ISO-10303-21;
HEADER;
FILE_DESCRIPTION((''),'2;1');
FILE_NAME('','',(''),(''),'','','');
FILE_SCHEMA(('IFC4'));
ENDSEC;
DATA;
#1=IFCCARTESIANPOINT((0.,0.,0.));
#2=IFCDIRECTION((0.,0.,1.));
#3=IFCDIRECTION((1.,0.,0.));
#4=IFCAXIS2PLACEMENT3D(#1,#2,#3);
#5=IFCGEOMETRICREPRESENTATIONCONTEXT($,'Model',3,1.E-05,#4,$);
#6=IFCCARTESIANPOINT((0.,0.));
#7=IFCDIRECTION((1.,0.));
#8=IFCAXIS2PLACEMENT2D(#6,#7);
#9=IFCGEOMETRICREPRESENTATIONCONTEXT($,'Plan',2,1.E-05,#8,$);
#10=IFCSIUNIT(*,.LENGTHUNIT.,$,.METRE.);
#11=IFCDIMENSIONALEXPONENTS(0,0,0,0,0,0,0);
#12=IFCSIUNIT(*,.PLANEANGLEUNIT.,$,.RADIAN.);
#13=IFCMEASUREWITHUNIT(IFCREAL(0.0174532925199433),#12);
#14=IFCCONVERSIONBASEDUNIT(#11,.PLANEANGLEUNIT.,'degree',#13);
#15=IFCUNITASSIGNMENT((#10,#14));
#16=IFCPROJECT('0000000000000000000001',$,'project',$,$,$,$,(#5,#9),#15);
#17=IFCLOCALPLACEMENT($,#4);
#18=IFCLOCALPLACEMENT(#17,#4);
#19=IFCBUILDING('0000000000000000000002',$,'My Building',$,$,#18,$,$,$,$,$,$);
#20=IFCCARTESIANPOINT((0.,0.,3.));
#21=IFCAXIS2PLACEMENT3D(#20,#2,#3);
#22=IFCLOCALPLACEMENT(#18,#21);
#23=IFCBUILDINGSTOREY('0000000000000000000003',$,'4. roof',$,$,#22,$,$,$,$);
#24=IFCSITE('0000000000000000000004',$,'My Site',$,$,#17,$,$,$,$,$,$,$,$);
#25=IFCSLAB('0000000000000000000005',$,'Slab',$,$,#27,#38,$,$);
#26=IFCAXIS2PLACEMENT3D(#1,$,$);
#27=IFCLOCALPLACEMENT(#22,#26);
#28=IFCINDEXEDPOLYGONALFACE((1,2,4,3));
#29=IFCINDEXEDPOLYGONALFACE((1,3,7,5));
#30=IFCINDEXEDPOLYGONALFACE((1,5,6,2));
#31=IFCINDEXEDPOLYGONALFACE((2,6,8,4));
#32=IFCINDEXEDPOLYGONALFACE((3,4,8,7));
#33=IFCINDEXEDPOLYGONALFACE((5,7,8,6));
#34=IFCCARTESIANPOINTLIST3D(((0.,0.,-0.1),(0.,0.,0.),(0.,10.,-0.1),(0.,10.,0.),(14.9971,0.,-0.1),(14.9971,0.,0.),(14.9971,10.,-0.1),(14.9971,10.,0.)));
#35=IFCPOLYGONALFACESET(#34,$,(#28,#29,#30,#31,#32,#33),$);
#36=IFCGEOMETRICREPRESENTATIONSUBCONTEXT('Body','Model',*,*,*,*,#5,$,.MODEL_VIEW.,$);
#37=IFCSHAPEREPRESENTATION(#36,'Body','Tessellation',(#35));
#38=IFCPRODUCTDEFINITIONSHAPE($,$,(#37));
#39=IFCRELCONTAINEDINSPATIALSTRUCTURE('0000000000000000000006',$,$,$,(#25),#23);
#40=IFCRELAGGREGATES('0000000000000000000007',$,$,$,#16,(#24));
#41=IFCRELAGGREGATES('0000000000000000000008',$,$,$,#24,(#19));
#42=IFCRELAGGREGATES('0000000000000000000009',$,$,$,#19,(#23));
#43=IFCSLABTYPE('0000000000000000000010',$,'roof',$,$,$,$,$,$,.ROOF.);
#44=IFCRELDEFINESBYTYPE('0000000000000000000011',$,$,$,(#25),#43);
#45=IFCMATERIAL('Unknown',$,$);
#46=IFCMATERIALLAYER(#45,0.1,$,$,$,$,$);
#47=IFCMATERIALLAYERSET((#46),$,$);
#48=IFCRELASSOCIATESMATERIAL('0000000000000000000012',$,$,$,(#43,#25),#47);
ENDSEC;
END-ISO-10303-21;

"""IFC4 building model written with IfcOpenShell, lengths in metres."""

from ifc_helpers import new_model, entity, si_unit, converted_unit, frame, origin_with_axes, origin_2d_with_axis, place, context, subcontext, project, spatial, indexed_curve, outline, extrude, material, layer, layer_set, layer_usage, type_object, element, save


model = new_model("IFC4")

# Units and contexts
model_context = context("Model", 3, precision=1e-05, world=origin_with_axes())
plan_context = context("Plan", 2, precision=1e-05, world=origin_2d_with_axis())
body_context = subcontext(model_context, "Body", "Model", "MODEL_VIEW")
ifc_project = project(units=[si_unit("LENGTHUNIT", "METRE"), converted_unit("PLANEANGLEUNIT", "degree", entity("IfcReal", 0.0174532925199433), si_unit("PLANEANGLEUNIT", "RADIAN"), dimensions=[0, 0, 0, 0, 0, 0, 0])], contexts=[model_context, plan_context])

# Site, building, storey
site_placement = place(None, origin_with_axes())
site = spatial("IfcSite", under=ifc_project, at=site_placement, Name="My Site")
building_placement = place(site_placement, origin_with_axes())
building = spatial("IfcBuilding", under=site, at=building_placement, Name="My Building")
storey_placement = place(building_placement, frame((0.0, 0.0, 3.0), z_axis=(0.0, 0.0, 1.0), x_axis=(1.0, 0.0, 0.0)))
storey = spatial("IfcBuildingStorey", under=building, at=storey_placement, Name="4. roof")

# Slab
ifc_material = material(Name="Unknown")
ifc_layer = layer(ifc_material, 0.1)
ifc_layer_set = layer_set([ifc_layer])
ifc_layer_usage = layer_usage(ifc_layer_set, "AXIS3", "POSITIVE", -0.1)
slab_type = type_object("IfcSlabType", Name="roof", PredefinedType="ROOF", material=ifc_layer_set)
slab_placement = place(storey_placement, frame((0.0, 10.0, 0.0), z_axis=(0.0, 0.0, 1.0), x_axis=(1.0, 0.0, 0.0)))
element("IfcSlab", 1, at=slab_placement, inside=storey, type_object=slab_type, material=ifc_layer_usage, Name="Slab", context=body_context, shape_type="SweptSolid", body=[
    extrude(outline(indexed_curve([(0.0, 0.0), (14.9971, 0.0), (14.9971, -10.0), (0.0, -10.0), (0.0, 0.0)])), frame((0.0, 0.0, -0.1), z_axis=(0.0, 0.0, 1.0), x_axis=(1.0, 0.0, 0.0)), (0.0, 0.0, 1.0), 0.1),
])

save(model, "model.ifc")
